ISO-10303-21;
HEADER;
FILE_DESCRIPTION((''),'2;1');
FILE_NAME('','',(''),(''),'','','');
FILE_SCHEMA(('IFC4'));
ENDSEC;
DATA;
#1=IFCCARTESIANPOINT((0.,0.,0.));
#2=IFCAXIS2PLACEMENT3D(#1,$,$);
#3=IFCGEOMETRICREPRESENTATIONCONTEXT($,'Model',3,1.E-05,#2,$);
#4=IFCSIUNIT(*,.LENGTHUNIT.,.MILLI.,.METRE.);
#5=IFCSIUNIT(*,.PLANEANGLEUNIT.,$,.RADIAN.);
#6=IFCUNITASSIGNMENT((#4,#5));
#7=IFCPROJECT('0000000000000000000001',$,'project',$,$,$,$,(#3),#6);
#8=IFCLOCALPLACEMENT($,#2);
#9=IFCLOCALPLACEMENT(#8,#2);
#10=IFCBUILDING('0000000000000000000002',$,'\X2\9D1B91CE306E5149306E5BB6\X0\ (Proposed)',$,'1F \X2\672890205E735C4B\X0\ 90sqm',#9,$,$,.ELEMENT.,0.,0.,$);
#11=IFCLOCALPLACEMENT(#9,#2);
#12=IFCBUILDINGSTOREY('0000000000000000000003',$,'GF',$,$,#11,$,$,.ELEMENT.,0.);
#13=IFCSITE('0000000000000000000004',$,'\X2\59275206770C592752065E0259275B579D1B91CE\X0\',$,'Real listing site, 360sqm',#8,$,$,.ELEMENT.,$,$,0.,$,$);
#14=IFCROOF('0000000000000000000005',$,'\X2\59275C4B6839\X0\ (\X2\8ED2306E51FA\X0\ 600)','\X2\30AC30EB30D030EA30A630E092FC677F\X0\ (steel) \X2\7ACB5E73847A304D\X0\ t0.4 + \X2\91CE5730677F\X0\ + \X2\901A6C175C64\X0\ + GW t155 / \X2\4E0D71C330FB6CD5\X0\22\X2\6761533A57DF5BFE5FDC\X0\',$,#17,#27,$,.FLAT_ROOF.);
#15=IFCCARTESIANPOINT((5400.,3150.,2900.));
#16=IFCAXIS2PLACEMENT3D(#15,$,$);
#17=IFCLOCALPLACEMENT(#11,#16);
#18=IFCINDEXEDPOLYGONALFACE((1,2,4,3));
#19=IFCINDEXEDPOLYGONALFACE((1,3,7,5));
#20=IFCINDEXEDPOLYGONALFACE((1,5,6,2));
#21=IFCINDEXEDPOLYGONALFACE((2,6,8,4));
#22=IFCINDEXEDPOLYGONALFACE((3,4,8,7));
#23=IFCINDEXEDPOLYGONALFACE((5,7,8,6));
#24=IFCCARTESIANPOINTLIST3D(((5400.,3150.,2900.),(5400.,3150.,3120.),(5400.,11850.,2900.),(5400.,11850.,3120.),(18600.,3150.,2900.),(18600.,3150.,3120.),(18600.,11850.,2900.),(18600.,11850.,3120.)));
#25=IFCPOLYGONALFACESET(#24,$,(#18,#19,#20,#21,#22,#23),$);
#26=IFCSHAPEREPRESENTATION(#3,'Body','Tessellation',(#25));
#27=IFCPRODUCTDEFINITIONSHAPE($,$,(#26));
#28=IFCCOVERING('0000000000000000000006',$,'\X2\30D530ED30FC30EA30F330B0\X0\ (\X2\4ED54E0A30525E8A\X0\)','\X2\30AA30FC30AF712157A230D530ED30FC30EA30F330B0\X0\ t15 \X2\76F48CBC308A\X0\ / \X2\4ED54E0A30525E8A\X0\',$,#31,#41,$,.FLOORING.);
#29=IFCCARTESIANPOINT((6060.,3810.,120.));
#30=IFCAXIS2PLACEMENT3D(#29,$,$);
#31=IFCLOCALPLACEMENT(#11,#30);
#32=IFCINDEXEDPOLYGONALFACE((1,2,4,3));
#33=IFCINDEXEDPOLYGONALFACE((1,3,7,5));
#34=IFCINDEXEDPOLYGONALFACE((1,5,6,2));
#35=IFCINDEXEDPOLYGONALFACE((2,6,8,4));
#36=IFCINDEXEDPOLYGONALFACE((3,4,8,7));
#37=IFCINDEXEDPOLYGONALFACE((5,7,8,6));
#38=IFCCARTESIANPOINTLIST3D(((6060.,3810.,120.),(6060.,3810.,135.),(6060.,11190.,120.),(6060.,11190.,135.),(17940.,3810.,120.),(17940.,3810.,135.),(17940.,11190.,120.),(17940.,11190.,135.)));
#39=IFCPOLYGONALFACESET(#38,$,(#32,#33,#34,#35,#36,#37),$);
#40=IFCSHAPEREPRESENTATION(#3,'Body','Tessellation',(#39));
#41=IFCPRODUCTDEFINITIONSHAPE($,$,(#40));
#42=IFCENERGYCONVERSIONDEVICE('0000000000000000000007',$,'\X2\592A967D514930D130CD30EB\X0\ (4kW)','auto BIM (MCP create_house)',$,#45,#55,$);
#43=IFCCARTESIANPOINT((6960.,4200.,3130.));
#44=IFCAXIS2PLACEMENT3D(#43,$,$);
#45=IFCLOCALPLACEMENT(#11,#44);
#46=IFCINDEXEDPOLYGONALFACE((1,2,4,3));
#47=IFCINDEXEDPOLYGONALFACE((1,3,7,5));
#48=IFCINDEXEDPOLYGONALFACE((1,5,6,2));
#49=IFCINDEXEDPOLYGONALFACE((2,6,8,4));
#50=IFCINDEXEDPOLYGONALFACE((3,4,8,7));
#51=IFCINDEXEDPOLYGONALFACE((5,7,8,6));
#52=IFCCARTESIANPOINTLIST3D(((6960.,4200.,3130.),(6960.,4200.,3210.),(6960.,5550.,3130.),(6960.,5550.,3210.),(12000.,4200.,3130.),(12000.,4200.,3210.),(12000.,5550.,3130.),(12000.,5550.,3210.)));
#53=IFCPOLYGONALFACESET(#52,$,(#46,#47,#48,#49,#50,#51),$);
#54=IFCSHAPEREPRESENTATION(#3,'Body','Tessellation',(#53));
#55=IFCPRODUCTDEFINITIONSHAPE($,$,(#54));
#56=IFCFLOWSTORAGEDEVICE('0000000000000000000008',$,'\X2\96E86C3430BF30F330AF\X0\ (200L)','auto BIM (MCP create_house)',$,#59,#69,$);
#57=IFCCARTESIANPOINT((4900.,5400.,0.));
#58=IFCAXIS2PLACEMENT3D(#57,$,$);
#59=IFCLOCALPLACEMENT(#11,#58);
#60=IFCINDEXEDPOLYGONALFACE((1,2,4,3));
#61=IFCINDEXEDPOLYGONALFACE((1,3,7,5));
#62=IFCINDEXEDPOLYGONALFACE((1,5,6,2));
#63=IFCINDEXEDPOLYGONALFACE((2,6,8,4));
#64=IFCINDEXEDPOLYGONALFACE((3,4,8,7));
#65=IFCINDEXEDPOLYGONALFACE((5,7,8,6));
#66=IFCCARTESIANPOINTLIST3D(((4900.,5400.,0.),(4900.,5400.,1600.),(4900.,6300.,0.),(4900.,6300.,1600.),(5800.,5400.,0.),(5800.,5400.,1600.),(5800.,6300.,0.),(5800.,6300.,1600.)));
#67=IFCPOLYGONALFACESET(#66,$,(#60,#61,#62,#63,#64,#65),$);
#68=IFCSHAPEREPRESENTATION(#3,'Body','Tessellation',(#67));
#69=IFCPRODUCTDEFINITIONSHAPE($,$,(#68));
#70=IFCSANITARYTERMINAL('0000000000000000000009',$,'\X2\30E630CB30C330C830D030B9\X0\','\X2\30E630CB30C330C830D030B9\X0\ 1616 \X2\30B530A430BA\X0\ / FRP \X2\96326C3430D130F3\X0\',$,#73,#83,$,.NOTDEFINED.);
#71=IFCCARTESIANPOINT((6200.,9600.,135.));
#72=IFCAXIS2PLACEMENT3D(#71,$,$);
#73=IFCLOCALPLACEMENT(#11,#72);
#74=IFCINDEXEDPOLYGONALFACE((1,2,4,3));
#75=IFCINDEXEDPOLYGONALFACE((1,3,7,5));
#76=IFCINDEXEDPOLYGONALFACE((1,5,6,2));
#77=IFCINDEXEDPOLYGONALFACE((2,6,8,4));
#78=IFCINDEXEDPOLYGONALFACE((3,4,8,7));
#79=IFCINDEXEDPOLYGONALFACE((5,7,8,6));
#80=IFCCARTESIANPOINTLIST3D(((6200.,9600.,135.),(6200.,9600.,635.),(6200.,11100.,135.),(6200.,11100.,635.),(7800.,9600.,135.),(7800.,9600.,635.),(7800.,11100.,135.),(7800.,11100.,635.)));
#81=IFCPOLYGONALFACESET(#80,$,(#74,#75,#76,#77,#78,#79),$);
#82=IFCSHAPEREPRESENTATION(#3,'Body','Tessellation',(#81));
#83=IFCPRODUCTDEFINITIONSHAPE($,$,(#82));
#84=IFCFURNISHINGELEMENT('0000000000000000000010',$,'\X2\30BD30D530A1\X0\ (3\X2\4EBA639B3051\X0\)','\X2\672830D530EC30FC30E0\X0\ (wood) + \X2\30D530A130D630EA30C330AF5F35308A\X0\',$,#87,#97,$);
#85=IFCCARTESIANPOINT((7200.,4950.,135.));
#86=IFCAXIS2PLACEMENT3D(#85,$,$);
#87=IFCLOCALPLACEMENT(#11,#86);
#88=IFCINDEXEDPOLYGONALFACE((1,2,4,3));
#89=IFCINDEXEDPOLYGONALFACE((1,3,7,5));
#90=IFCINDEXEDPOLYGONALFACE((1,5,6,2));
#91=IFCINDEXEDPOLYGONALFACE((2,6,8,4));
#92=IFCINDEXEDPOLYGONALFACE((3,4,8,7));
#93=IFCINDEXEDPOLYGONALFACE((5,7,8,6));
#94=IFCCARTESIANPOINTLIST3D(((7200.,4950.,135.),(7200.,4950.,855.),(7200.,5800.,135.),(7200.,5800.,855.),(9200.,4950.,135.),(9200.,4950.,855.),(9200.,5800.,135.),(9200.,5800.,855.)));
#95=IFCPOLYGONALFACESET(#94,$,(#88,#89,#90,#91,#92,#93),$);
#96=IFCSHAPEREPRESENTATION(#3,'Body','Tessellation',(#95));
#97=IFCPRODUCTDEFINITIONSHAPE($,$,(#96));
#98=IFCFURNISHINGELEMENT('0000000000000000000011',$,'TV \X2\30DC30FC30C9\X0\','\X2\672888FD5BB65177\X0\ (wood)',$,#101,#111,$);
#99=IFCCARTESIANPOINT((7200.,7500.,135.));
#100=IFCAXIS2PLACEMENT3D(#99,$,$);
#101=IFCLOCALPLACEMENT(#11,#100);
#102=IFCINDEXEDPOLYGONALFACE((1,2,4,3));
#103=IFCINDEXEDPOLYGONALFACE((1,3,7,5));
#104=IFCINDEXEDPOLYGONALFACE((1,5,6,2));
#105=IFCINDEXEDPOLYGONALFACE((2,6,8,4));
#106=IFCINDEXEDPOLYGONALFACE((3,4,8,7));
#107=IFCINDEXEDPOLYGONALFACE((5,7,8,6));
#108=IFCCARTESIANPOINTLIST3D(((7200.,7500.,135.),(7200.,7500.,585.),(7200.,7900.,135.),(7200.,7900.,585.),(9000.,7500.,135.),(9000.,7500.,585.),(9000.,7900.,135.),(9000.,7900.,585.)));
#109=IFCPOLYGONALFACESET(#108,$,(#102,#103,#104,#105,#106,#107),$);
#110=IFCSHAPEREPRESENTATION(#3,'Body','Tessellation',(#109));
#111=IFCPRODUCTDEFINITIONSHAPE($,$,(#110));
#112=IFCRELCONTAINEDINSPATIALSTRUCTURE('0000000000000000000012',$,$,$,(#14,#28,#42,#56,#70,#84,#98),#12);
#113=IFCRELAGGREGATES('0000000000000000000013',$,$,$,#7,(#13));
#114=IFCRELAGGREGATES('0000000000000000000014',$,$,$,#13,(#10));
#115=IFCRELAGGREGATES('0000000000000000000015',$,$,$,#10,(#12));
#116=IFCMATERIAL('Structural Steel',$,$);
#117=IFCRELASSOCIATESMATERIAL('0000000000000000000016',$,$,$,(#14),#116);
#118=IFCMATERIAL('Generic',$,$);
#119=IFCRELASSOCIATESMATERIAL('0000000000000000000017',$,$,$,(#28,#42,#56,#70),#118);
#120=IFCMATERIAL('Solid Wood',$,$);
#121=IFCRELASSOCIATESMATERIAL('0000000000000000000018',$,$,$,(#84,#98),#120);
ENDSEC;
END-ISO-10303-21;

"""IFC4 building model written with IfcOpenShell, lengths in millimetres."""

from ifc_helpers import new_model, si_unit, frame, frame_2d, origin, place, context, project, spatial, rectangle, extrude, material, element, save


model = new_model("IFC4")

# Units and contexts
model_context = context("Model", 3, precision=1e-05, world=origin())
ifc_project = project(units=[si_unit("LENGTHUNIT", "METRE", prefix="MILLI"), si_unit("PLANEANGLEUNIT", "RADIAN")], contexts=[model_context])

# Site, building, storey
site_placement = place(None, origin())
site = spatial("IfcSite", under=ifc_project, at=site_placement, Name="大分県大分市大字鴛野", ObjectType="Real listing site, 360sqm", CompositionType="ELEMENT", RefElevation=0.0)
building_placement = place(site_placement, origin())
building = spatial("IfcBuilding", under=site, at=building_placement, Name="鴛野の光の家 (Proposed)", ObjectType="1F 木造平屋 90sqm", CompositionType="ELEMENT", ElevationOfRefHeight=0.0, ElevationOfTerrain=0.0)
storey_placement = place(building_placement, origin())
storey = spatial("IfcBuildingStorey", under=building, at=storey_placement, Name="GF", CompositionType="ELEMENT", Elevation=0.0)

# Shared definitions
ifc_material_1 = material(Name="Solid Wood")

# Roof
ifc_material_2 = material(Name="Structural Steel")
roof_placement = place(storey_placement, frame((5400.0, 3150.0, 2900.0)))
element("IfcRoof", 1, at=roof_placement, inside=storey, material=ifc_material_2, Name="大屋根 (軒の出 600)", Description="ガルバリウム鋼板 (steel) 立平葺き t0.4 + 野地板 + 通気層 + GW t155 / 不燃・法22条区域対応", PredefinedType="FLAT_ROOF", context=model_context, shape_type="SweptSolid", body=[
    extrude(rectangle(XDim=13200.0, YDim=8700.0, at=frame_2d((6600.0, 4350.0))), frame((5400.0, 3150.0, 2900.0)), (0.0, 0.0, 1.0), 220.0),
])

# Covering
ifc_material_3 = material(Name="Generic")
covering_placement = place(storey_placement, frame((6060.0, 3810.0, 120.0)))
element("IfcCovering", 2, at=covering_placement, inside=storey, material=ifc_material_3, Name="フローリング (仕上げ床)", Description="オーク無垢フローリング t15 直貼り / 仕上げ床", PredefinedType="FLOORING", context=model_context, shape_type="SweptSolid", body=[
    extrude(rectangle(XDim=11880.0, YDim=7380.0, at=frame_2d((5940.0, 3690.0))), frame((6060.0, 3810.0, 120.0)), (0.0, 0.0, 1.0), 15.0),
])

# Energy conversion device
energy_conversion_device_placement = place(storey_placement, frame((6960.0, 4200.0, 3130.0)))
element("IfcEnergyConversionDevice", 3, at=energy_conversion_device_placement, inside=storey, material=ifc_material_3, Name="太陽光パネル (4kW)", Description="auto BIM (MCP create_house)", context=model_context, shape_type="SweptSolid", body=[
    extrude(rectangle(XDim=5040.0, YDim=1350.0, at=frame_2d((2520.0, 675.0))), frame((6960.0, 4200.0, 3130.0)), (0.0, 0.0, 1.0), 80.0),
])

# Flow storage device
flow_storage_device_placement = place(storey_placement, frame((4900.0, 5400.0, 0.0)))
element("IfcFlowStorageDevice", 4, at=flow_storage_device_placement, inside=storey, material=ifc_material_3, Name="雨水タンク (200L)", Description="auto BIM (MCP create_house)", context=model_context, shape_type="SweptSolid", body=[
    extrude(rectangle(XDim=900.0, YDim=900.0, at=frame_2d((450.0, 450.0))), frame((4900.0, 5400.0, 0.0)), (0.0, 0.0, 1.0), 1600.0),
])

# Sanitary terminal
sanitary_terminal_placement = place(storey_placement, frame((6200.0, 9600.0, 135.0)))
element("IfcSanitaryTerminal", 5, at=sanitary_terminal_placement, inside=storey, material=ifc_material_3, Name="ユニットバス", Description="ユニットバス 1616 サイズ / FRP 防水パン", PredefinedType="NOTDEFINED", context=model_context, shape_type="SweptSolid", body=[
    extrude(rectangle(XDim=1600.0, YDim=1500.0, at=frame_2d((800.0, 750.0))), frame((6200.0, 9600.0, 135.0)), (0.0, 0.0, 1.0), 500.0),
])

# Furnishing elements
furnishing_1_placement = place(storey_placement, frame((7200.0, 4950.0, 135.0)))
element("IfcFurnishingElement", 6, at=furnishing_1_placement, inside=storey, material=ifc_material_1, Name="ソファ (3人掛け)", Description="木フレーム (wood) + ファブリック張り", context=model_context, shape_type="SweptSolid", body=[
    extrude(rectangle(XDim=2000.0, YDim=850.0, at=frame_2d((1000.0, 425.0))), frame((7200.0, 4950.0, 135.0)), (0.0, 0.0, 1.0), 720.0),
])
furnishing_2_placement = place(storey_placement, frame((7200.0, 7500.0, 135.0)))
element("IfcFurnishingElement", 7, at=furnishing_2_placement, inside=storey, material=ifc_material_1, Name="TV ボード", Description="木製家具 (wood)", context=model_context, shape_type="SweptSolid", body=[
    extrude(rectangle(XDim=1800.0, YDim=400.0, at=frame_2d((900.0, 200.0))), frame((7200.0, 7500.0, 135.0)), (0.0, 0.0, 1.0), 450.0),
])

save(model, "model.ifc")
